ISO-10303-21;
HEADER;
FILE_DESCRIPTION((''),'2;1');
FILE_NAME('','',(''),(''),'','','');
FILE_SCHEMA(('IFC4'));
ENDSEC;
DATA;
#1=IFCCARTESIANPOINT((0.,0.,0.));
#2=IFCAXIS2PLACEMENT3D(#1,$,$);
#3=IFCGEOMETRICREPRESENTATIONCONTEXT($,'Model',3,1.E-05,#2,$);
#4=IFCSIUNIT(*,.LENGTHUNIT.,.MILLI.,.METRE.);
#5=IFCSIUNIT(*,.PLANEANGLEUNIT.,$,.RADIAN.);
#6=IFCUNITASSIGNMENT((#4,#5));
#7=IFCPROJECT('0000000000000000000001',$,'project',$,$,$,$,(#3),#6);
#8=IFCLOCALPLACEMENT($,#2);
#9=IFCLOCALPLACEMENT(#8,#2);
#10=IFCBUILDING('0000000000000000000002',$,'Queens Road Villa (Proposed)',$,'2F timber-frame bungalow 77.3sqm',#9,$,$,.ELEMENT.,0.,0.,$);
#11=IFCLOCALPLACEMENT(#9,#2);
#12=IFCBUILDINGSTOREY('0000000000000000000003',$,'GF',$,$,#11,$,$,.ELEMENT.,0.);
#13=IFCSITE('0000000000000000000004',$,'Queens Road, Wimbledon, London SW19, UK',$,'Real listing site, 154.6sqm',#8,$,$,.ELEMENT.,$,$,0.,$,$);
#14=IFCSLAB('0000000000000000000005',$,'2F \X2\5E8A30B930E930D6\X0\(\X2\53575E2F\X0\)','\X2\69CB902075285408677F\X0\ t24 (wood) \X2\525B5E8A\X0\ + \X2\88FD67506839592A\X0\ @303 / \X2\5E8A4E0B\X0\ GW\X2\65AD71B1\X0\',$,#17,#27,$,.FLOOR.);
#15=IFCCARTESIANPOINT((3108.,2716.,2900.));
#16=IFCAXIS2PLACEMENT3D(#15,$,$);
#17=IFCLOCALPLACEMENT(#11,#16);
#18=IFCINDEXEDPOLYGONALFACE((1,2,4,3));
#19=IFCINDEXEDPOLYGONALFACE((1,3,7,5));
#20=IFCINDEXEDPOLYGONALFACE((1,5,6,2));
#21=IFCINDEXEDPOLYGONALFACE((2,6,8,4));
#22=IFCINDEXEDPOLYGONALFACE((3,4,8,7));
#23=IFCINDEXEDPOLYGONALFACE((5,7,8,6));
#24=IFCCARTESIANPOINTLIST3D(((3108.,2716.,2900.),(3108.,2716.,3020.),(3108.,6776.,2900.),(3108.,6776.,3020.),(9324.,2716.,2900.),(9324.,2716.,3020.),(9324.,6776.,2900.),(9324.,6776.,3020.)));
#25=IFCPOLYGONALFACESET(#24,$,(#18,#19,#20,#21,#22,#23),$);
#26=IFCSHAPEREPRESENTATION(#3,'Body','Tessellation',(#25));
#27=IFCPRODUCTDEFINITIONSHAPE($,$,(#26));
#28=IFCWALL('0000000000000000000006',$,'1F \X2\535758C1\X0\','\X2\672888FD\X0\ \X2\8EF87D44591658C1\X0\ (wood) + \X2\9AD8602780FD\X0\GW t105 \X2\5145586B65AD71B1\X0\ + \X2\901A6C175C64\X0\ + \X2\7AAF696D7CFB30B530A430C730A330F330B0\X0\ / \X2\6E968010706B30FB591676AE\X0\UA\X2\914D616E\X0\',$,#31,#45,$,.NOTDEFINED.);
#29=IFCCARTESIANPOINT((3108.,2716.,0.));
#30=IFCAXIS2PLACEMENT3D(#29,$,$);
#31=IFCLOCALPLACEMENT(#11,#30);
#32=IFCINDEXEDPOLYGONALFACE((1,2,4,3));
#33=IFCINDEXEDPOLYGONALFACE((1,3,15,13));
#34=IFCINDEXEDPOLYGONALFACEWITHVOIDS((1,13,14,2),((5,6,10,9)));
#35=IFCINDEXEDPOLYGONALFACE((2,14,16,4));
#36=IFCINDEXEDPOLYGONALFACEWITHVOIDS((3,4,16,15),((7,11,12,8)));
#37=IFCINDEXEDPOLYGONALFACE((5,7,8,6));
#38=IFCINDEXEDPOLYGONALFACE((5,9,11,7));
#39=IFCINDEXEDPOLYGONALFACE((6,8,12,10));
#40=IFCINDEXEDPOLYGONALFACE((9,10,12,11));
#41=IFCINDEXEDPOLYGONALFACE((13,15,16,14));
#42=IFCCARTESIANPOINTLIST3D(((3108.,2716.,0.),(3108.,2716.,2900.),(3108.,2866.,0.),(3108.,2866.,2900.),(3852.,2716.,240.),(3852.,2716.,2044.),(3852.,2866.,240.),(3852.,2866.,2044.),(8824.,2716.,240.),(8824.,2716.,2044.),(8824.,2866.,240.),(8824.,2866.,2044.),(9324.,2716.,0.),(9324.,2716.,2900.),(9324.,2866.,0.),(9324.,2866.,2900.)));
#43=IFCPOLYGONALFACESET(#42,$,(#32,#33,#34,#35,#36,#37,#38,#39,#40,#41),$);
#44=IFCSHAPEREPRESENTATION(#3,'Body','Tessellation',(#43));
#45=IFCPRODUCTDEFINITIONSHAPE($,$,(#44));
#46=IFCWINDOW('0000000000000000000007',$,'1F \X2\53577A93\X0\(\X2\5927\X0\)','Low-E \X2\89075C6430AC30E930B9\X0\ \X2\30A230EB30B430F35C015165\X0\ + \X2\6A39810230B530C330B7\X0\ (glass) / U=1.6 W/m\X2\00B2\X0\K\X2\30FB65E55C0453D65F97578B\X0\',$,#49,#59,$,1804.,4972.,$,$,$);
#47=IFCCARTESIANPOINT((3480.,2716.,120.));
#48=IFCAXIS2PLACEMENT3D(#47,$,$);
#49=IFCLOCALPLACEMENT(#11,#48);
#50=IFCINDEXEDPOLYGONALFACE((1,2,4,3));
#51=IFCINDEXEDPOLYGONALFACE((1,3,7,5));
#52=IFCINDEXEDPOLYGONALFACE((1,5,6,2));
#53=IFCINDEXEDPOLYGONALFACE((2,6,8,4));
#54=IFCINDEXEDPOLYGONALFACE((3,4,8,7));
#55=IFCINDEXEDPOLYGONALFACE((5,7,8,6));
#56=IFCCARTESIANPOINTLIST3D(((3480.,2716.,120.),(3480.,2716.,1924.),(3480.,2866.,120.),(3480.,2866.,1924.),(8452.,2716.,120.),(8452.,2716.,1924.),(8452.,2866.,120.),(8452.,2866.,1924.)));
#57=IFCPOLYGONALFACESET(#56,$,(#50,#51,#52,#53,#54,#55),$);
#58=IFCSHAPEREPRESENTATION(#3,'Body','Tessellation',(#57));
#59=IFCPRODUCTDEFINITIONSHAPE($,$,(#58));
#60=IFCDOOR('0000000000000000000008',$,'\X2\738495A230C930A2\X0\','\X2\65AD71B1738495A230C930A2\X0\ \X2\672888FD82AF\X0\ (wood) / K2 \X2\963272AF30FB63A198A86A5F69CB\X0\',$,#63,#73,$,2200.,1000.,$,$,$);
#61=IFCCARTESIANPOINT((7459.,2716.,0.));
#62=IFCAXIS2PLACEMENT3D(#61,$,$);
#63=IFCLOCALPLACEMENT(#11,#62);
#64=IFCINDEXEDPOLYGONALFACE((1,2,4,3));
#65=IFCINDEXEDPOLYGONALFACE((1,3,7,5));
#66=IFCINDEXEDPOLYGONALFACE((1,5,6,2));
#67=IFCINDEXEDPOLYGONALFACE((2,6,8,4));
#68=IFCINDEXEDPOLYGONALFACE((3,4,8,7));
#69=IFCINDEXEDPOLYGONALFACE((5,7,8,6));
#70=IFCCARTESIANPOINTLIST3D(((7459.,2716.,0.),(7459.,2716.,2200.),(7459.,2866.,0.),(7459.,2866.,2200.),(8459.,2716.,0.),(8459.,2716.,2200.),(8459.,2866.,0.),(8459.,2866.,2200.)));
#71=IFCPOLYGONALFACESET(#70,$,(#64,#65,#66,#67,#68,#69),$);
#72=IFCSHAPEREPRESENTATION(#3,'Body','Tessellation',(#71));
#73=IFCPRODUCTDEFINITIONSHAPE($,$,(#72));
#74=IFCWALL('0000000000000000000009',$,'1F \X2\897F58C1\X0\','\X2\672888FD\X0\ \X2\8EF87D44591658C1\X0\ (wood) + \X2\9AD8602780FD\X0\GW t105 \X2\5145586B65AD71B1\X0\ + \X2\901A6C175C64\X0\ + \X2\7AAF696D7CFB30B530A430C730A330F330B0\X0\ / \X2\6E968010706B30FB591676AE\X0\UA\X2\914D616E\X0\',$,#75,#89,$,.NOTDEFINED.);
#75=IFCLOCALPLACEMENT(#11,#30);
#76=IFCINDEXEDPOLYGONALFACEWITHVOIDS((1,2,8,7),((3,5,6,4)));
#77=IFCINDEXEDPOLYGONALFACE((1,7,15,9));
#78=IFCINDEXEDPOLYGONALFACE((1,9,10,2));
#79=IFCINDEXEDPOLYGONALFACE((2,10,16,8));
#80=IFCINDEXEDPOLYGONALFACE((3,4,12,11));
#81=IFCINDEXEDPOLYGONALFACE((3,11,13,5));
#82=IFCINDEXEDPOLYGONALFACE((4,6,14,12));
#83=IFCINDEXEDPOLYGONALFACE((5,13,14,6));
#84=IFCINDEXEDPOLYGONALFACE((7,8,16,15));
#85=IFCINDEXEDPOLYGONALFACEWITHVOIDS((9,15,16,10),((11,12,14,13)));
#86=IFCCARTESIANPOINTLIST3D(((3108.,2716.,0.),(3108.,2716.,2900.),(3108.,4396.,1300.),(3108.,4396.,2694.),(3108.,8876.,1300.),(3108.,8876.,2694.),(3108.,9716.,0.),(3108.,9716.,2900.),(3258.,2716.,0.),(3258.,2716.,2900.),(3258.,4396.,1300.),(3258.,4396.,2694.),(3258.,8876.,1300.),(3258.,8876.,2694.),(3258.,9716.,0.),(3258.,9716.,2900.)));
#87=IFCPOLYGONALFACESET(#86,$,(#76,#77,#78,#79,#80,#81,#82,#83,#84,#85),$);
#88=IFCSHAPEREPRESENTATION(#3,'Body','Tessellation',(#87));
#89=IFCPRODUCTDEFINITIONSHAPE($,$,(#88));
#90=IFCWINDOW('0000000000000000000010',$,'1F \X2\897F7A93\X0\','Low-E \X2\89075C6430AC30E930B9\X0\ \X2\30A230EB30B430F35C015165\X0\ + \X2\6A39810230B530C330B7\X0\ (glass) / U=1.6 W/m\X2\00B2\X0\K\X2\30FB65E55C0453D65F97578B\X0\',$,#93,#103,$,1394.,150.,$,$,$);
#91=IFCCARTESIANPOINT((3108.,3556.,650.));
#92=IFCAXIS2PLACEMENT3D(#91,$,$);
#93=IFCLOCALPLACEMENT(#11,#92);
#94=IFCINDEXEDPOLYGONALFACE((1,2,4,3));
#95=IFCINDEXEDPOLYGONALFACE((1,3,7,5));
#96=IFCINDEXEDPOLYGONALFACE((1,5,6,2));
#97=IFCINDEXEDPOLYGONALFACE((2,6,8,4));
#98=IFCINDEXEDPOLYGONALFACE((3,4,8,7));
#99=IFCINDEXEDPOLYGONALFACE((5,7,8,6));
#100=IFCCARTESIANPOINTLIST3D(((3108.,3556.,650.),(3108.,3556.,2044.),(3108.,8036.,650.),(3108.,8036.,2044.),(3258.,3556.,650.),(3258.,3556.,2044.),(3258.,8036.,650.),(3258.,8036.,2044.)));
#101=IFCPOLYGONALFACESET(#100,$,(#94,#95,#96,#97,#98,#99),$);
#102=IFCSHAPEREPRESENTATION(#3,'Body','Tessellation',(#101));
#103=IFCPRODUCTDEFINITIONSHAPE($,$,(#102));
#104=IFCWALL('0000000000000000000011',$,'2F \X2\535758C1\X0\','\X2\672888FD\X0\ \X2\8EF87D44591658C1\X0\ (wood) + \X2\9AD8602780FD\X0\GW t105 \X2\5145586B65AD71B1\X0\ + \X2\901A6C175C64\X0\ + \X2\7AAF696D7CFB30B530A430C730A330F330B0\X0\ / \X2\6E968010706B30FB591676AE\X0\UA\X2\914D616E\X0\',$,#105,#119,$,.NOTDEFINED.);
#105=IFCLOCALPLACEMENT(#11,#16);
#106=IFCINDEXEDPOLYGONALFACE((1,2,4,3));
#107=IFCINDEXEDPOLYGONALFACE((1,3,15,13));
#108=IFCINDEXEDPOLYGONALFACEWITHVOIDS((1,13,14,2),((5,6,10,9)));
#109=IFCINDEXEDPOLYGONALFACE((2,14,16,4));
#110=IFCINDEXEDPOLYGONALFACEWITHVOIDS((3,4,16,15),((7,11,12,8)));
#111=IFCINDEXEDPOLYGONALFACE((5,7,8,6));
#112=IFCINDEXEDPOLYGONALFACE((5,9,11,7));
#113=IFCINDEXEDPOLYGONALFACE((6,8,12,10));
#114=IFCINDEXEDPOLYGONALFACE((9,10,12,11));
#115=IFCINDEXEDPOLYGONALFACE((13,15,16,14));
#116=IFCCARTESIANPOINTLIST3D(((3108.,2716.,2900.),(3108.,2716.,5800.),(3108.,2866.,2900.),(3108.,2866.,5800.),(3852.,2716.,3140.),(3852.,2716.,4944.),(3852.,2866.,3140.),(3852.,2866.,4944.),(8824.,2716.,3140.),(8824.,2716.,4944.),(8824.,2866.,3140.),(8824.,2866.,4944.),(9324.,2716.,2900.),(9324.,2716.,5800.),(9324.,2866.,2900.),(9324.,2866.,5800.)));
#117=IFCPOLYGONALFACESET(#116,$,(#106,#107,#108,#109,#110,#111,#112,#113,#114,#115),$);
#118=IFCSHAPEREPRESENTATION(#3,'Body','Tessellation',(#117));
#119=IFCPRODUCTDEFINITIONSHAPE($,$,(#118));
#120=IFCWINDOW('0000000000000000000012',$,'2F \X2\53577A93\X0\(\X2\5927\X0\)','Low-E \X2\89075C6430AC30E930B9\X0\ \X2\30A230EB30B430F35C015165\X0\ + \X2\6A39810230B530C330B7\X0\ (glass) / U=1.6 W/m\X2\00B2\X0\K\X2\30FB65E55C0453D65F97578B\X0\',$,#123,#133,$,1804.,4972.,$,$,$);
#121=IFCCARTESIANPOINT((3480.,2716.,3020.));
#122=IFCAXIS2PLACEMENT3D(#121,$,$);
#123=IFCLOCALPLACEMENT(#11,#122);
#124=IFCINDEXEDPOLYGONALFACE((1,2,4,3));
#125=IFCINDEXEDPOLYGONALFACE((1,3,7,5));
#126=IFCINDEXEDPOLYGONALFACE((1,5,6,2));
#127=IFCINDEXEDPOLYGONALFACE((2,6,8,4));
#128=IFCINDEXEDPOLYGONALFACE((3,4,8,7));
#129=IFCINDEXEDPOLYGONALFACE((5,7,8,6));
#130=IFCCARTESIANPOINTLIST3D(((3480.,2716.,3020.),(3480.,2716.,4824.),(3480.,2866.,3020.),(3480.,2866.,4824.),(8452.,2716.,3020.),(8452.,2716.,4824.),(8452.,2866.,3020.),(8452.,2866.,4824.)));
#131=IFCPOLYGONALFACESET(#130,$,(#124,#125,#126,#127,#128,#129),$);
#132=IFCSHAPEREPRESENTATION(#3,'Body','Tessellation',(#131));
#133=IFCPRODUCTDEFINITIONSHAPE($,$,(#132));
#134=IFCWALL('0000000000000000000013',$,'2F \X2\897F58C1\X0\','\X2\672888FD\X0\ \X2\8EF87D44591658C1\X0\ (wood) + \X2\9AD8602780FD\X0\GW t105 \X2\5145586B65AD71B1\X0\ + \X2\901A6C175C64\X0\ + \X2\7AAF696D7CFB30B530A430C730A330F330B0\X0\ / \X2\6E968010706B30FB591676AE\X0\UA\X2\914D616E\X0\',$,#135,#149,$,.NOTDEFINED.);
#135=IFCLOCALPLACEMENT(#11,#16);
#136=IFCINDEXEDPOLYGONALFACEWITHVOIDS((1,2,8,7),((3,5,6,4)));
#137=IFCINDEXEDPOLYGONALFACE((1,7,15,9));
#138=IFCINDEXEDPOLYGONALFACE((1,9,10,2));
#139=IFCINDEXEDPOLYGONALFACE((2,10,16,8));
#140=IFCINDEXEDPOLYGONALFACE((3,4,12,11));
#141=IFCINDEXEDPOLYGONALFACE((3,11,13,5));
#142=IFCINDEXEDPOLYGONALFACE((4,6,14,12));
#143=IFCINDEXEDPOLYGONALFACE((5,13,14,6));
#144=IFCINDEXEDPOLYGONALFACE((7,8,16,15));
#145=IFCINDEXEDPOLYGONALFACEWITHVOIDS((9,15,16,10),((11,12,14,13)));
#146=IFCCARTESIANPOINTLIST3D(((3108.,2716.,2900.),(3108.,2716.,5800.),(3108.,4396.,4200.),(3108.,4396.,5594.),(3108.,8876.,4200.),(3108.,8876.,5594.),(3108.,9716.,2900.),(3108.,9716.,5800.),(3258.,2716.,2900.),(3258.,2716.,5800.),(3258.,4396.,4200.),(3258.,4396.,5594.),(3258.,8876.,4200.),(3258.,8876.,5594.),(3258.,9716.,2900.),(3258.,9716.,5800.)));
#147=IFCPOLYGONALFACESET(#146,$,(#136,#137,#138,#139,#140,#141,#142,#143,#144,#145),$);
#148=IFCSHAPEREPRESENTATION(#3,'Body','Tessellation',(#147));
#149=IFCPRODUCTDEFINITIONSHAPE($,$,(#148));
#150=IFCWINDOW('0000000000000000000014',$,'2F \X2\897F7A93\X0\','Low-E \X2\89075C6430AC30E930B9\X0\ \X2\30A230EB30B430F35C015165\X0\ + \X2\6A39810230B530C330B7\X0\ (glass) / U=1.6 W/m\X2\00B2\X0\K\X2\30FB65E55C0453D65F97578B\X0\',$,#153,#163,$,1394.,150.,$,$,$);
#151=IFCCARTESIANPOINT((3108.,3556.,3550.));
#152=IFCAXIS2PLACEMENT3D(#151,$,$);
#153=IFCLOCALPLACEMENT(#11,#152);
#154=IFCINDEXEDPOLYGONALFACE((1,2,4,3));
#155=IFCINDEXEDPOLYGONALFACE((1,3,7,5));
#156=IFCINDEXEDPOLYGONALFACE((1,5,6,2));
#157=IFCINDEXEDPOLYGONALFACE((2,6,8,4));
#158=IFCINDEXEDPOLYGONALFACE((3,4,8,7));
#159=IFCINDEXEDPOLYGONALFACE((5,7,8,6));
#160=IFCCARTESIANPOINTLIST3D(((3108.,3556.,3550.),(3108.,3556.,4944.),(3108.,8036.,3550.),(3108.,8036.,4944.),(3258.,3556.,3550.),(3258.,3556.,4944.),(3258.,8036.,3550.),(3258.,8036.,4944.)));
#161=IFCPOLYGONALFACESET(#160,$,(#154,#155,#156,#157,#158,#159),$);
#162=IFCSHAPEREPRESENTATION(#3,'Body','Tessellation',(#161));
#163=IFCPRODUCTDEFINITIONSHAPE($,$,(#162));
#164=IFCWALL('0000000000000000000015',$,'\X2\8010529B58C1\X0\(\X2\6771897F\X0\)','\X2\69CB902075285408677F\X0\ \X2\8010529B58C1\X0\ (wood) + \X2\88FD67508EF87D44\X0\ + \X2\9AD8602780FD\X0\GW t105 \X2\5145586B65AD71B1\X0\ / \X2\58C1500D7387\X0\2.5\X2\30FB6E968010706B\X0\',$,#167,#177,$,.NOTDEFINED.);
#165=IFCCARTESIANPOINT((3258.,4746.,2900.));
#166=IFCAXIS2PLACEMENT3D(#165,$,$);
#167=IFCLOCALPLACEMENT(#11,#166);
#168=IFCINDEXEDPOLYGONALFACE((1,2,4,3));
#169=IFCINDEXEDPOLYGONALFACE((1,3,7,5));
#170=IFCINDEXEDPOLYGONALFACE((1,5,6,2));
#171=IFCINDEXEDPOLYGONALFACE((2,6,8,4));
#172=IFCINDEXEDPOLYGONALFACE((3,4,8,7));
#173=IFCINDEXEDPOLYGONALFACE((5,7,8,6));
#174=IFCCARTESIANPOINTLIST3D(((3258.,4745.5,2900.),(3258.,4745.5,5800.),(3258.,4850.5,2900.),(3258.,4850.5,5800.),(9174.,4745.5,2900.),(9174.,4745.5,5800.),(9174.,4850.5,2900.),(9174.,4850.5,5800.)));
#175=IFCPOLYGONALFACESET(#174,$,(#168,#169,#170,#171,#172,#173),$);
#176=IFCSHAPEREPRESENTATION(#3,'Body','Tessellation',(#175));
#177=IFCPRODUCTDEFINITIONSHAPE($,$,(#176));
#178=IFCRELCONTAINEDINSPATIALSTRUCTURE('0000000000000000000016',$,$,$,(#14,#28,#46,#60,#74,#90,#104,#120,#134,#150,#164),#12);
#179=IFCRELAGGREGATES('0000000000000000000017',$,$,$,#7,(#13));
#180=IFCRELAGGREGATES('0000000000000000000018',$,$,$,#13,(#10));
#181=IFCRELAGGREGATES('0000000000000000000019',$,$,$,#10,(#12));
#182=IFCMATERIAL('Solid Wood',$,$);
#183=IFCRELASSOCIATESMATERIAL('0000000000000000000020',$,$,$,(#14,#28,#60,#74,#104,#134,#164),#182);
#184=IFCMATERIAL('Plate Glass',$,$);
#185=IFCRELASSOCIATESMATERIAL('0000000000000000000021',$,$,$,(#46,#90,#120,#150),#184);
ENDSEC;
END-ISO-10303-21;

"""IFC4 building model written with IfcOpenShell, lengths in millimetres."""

from ifc_helpers import new_model, si_unit, frame, frame_2d, origin, place, context, project, spatial, rectangle, extrude, material, element, fill, save


model = new_model("IFC4")

# Units and contexts
model_context = context("Model", 3, precision=1e-05, world=origin())
ifc_project = project(units=[si_unit("LENGTHUNIT", "METRE", prefix="MILLI"), si_unit("PLANEANGLEUNIT", "RADIAN")], contexts=[model_context])

# Site, building, storey
site_placement = place(None, origin())
site = spatial("IfcSite", under=ifc_project, at=site_placement, Name="Queens Road, Wimbledon, London SW19, UK", ObjectType="Real listing site, 154.6sqm", CompositionType="ELEMENT", RefElevation=0.0)
building_placement = place(site_placement, origin())
building = spatial("IfcBuilding", under=site, at=building_placement, Name="Queens Road Villa (Proposed)", ObjectType="2F timber-frame bungalow 77.3sqm", CompositionType="ELEMENT", ElevationOfRefHeight=0.0, ElevationOfTerrain=0.0)
storey_placement = place(building_placement, origin())
storey = spatial("IfcBuildingStorey", under=building, at=storey_placement, Name="GF", CompositionType="ELEMENT", Elevation=0.0)

# Slab
ifc_material_1 = material(Name="Solid Wood")
slab_1_placement = place(storey_placement, frame((3108.0, 2716.0, 2900.0)))
element("IfcSlab", 1, at=slab_1_placement, inside=storey, material=ifc_material_1, Name="2F 床スラブ(南帯)", Description="構造用合板 t24 (wood) 剛床 + 製材根太 @303 / 床下 GW断熱", PredefinedType="FLOOR", context=model_context, shape_type="SweptSolid", body=[
    extrude(rectangle(XDim=6216.0, YDim=4060.0, at=frame_2d((3108.0, 2030.0))), frame((3108.0, 2716.0, 2900.0)), (0.0, 0.0, 1.0), 120.0),
])

# Wall, openings, window, door
wall_1_placement = place(storey_placement, frame((3108.0, 2716.0, 0.0)))
wall_1 = element("IfcWall", 2, at=wall_1_placement, inside=storey, material=ifc_material_1, Name="1F 南壁", Description="木製 軸組外壁 (wood) + 高性能GW t105 充填断熱 + 通気層 + 窯業系サイディング / 準耐火・外皮UA配慮", PredefinedType="NOTDEFINED", context=model_context, shape_type="SweptSolid", body=[
    extrude(rectangle(XDim=6216.0, YDim=150.0, at=frame_2d((3108.0, 75.0))), frame((3108.0, 2716.0, 0.0)), (0.0, 0.0, 1.0), 2900.0),
])
opening_1_placement = place(storey_placement, frame((3480.0, 2716.0, 120.0)))
opening_1 = element("IfcOpeningElement", 3, at=opening_1_placement, cuts=wall_1, PredefinedType="NOTDEFINED", context=model_context, shape_type="SweptSolid", body=[
    extrude(rectangle(XDim=4972.0, YDim=150.0, at=frame_2d((2486.0, 75.0))), frame((3480.0, 2716.0, 120.0)), (0.0, 0.0, 1.0), 1804.0),
])
opening_2_placement = place(storey_placement, frame((7459.0, 2716.0, 0.0)))
opening_2 = element("IfcOpeningElement", 4, at=opening_2_placement, cuts=wall_1, PredefinedType="NOTDEFINED", context=model_context, shape_type="SweptSolid", body=[
    extrude(rectangle(XDim=1000.0, YDim=150.0, at=frame_2d((500.0, 75.0))), frame((7459.0, 2716.0, 0.0)), (0.0, 0.0, 1.0), 2200.0),
])
ifc_material_2 = material(Name="Plate Glass")
window_1_placement = place(storey_placement, frame((3480.0, 2716.0, 120.0)))
window_1 = element("IfcWindow", 5, at=window_1_placement, inside=storey, material=ifc_material_2, Name="1F 南窓(大)", Description="Low-E 複層ガラス アルゴン封入 + 樹脂サッシ (glass) / U=1.6 W/m²K・日射取得型", OverallHeight=1804.0, OverallWidth=4972.0, context=model_context, shape_type="SweptSolid", body=[
    extrude(rectangle(XDim=4972.0, YDim=150.0, at=frame_2d((2486.0, 75.0))), frame((3480.0, 2716.0, 120.0)), (0.0, 0.0, 1.0), 1804.0),
])
fill(opening_1, window_1)
door_placement = place(storey_placement, frame((7459.0, 2716.0, 0.0)))
door = element("IfcDoor", 6, at=door_placement, inside=storey, material=ifc_material_1, Name="玄関ドア", Description="断熱玄関ドア 木製芯 (wood) / K2 防犯・採風機構", OverallHeight=2200.0, OverallWidth=1000.0, context=model_context, shape_type="SweptSolid", body=[
    extrude(rectangle(XDim=1000.0, YDim=150.0, at=frame_2d((500.0, 75.0))), frame((7459.0, 2716.0, 0.0)), (0.0, 0.0, 1.0), 2200.0),
])
fill(opening_2, door)

# Wall, opening, window
wall_2_placement = place(storey_placement, frame((3108.0, 2716.0, 0.0)))
wall_2 = element("IfcWall", 7, at=wall_2_placement, inside=storey, material=ifc_material_1, Name="1F 西壁", Description="木製 軸組外壁 (wood) + 高性能GW t105 充填断熱 + 通気層 + 窯業系サイディング / 準耐火・外皮UA配慮", PredefinedType="NOTDEFINED", context=model_context, shape_type="SweptSolid", body=[
    extrude(rectangle(XDim=150.0, YDim=7000.0, at=frame_2d((75.0, 3500.0))), frame((3108.0, 2716.0, 0.0)), (0.0, 0.0, 1.0), 2900.0),
])
opening_3_placement = place(storey_placement, frame((3108.0, 3556.0, 650.0)))
opening_3 = element("IfcOpeningElement", 8, at=opening_3_placement, cuts=wall_2, PredefinedType="NOTDEFINED", context=model_context, shape_type="SweptSolid", body=[
    extrude(rectangle(XDim=150.0, YDim=4480.0, at=frame_2d((75.0, 2240.0))), frame((3108.0, 3556.0, 650.0)), (0.0, 0.0, 1.0), 1394.0),
])
window_2_placement = place(storey_placement, frame((3108.0, 3556.0, 650.0)))
window_2 = element("IfcWindow", 9, at=window_2_placement, inside=storey, material=ifc_material_2, Name="1F 西窓", Description="Low-E 複層ガラス アルゴン封入 + 樹脂サッシ (glass) / U=1.6 W/m²K・日射取得型", OverallHeight=1394.0, OverallWidth=150.0, context=model_context, shape_type="SweptSolid", body=[
    extrude(rectangle(XDim=150.0, YDim=4480.0, at=frame_2d((75.0, 2240.0))), frame((3108.0, 3556.0, 650.0)), (0.0, 0.0, 1.0), 1394.0),
])
fill(opening_3, window_2)

# Walls, openings, windows
wall_3_placement = place(storey_placement, frame((3108.0, 2716.0, 2900.0)))
wall_3 = element("IfcWall", 10, at=wall_3_placement, inside=storey, material=ifc_material_1, Name="2F 南壁", Description="木製 軸組外壁 (wood) + 高性能GW t105 充填断熱 + 通気層 + 窯業系サイディング / 準耐火・外皮UA配慮", PredefinedType="NOTDEFINED", context=model_context, shape_type="SweptSolid", body=[
    extrude(rectangle(XDim=6216.0, YDim=150.0, at=frame_2d((3108.0, 75.0))), frame((3108.0, 2716.0, 2900.0)), (0.0, 0.0, 1.0), 2900.0),
])
opening_4_placement = place(storey_placement, frame((3480.0, 2716.0, 3020.0)))
opening_4 = element("IfcOpeningElement", 11, at=opening_4_placement, cuts=wall_3, PredefinedType="NOTDEFINED", context=model_context, shape_type="SweptSolid", body=[
    extrude(rectangle(XDim=4972.0, YDim=150.0, at=frame_2d((2486.0, 75.0))), frame((3480.0, 2716.0, 3020.0)), (0.0, 0.0, 1.0), 1804.0),
])
window_3_placement = place(storey_placement, frame((3480.0, 2716.0, 3020.0)))
window_3 = element("IfcWindow", 12, at=window_3_placement, inside=storey, material=ifc_material_2, Name="2F 南窓(大)", Description="Low-E 複層ガラス アルゴン封入 + 樹脂サッシ (glass) / U=1.6 W/m²K・日射取得型", OverallHeight=1804.0, OverallWidth=4972.0, context=model_context, shape_type="SweptSolid", body=[
    extrude(rectangle(XDim=4972.0, YDim=150.0, at=frame_2d((2486.0, 75.0))), frame((3480.0, 2716.0, 3020.0)), (0.0, 0.0, 1.0), 1804.0),
])
fill(opening_4, window_3)
wall_4_placement = place(storey_placement, frame((3108.0, 2716.0, 2900.0)))
wall_4 = element("IfcWall", 13, at=wall_4_placement, inside=storey, material=ifc_material_1, Name="2F 西壁", Description="木製 軸組外壁 (wood) + 高性能GW t105 充填断熱 + 通気層 + 窯業系サイディング / 準耐火・外皮UA配慮", PredefinedType="NOTDEFINED", context=model_context, shape_type="SweptSolid", body=[
    extrude(rectangle(XDim=150.0, YDim=7000.0, at=frame_2d((75.0, 3500.0))), frame((3108.0, 2716.0, 2900.0)), (0.0, 0.0, 1.0), 2900.0),
])
opening_5_placement = place(storey_placement, frame((3108.0, 3556.0, 3550.0)))
opening_5 = element("IfcOpeningElement", 14, at=opening_5_placement, cuts=wall_4, PredefinedType="NOTDEFINED", context=model_context, shape_type="SweptSolid", body=[
    extrude(rectangle(XDim=150.0, YDim=4480.0, at=frame_2d((75.0, 2240.0))), frame((3108.0, 3556.0, 3550.0)), (0.0, 0.0, 1.0), 1394.0),
])
window_4_placement = place(storey_placement, frame((3108.0, 3556.0, 3550.0)))
window_4 = element("IfcWindow", 15, at=window_4_placement, inside=storey, material=ifc_material_2, Name="2F 西窓", Description="Low-E 複層ガラス アルゴン封入 + 樹脂サッシ (glass) / U=1.6 W/m²K・日射取得型", OverallHeight=1394.0, OverallWidth=150.0, context=model_context, shape_type="SweptSolid", body=[
    extrude(rectangle(XDim=150.0, YDim=4480.0, at=frame_2d((75.0, 2240.0))), frame((3108.0, 3556.0, 3550.0)), (0.0, 0.0, 1.0), 1394.0),
])
fill(opening_5, window_4)

# Wall
wall_5_placement = place(storey_placement, frame((3258.0, 4746.0, 2900.0)))
element("IfcWall", 16, at=wall_5_placement, inside=storey, material=ifc_material_1, Name="耐力壁(東西)", Description="構造用合板 耐力壁 (wood) + 製材軸組 + 高性能GW t105 充填断熱 / 壁倍率2.5・準耐火", PredefinedType="NOTDEFINED", context=model_context, shape_type="SweptSolid", body=[
    extrude(rectangle(XDim=5916.0, YDim=105.0, at=frame_2d((2958.0, 52.0))), frame((3258.0, 4746.0, 2900.0)), (0.0, 0.0, 1.0), 2900.0),
])

save(model, "model.ifc")
